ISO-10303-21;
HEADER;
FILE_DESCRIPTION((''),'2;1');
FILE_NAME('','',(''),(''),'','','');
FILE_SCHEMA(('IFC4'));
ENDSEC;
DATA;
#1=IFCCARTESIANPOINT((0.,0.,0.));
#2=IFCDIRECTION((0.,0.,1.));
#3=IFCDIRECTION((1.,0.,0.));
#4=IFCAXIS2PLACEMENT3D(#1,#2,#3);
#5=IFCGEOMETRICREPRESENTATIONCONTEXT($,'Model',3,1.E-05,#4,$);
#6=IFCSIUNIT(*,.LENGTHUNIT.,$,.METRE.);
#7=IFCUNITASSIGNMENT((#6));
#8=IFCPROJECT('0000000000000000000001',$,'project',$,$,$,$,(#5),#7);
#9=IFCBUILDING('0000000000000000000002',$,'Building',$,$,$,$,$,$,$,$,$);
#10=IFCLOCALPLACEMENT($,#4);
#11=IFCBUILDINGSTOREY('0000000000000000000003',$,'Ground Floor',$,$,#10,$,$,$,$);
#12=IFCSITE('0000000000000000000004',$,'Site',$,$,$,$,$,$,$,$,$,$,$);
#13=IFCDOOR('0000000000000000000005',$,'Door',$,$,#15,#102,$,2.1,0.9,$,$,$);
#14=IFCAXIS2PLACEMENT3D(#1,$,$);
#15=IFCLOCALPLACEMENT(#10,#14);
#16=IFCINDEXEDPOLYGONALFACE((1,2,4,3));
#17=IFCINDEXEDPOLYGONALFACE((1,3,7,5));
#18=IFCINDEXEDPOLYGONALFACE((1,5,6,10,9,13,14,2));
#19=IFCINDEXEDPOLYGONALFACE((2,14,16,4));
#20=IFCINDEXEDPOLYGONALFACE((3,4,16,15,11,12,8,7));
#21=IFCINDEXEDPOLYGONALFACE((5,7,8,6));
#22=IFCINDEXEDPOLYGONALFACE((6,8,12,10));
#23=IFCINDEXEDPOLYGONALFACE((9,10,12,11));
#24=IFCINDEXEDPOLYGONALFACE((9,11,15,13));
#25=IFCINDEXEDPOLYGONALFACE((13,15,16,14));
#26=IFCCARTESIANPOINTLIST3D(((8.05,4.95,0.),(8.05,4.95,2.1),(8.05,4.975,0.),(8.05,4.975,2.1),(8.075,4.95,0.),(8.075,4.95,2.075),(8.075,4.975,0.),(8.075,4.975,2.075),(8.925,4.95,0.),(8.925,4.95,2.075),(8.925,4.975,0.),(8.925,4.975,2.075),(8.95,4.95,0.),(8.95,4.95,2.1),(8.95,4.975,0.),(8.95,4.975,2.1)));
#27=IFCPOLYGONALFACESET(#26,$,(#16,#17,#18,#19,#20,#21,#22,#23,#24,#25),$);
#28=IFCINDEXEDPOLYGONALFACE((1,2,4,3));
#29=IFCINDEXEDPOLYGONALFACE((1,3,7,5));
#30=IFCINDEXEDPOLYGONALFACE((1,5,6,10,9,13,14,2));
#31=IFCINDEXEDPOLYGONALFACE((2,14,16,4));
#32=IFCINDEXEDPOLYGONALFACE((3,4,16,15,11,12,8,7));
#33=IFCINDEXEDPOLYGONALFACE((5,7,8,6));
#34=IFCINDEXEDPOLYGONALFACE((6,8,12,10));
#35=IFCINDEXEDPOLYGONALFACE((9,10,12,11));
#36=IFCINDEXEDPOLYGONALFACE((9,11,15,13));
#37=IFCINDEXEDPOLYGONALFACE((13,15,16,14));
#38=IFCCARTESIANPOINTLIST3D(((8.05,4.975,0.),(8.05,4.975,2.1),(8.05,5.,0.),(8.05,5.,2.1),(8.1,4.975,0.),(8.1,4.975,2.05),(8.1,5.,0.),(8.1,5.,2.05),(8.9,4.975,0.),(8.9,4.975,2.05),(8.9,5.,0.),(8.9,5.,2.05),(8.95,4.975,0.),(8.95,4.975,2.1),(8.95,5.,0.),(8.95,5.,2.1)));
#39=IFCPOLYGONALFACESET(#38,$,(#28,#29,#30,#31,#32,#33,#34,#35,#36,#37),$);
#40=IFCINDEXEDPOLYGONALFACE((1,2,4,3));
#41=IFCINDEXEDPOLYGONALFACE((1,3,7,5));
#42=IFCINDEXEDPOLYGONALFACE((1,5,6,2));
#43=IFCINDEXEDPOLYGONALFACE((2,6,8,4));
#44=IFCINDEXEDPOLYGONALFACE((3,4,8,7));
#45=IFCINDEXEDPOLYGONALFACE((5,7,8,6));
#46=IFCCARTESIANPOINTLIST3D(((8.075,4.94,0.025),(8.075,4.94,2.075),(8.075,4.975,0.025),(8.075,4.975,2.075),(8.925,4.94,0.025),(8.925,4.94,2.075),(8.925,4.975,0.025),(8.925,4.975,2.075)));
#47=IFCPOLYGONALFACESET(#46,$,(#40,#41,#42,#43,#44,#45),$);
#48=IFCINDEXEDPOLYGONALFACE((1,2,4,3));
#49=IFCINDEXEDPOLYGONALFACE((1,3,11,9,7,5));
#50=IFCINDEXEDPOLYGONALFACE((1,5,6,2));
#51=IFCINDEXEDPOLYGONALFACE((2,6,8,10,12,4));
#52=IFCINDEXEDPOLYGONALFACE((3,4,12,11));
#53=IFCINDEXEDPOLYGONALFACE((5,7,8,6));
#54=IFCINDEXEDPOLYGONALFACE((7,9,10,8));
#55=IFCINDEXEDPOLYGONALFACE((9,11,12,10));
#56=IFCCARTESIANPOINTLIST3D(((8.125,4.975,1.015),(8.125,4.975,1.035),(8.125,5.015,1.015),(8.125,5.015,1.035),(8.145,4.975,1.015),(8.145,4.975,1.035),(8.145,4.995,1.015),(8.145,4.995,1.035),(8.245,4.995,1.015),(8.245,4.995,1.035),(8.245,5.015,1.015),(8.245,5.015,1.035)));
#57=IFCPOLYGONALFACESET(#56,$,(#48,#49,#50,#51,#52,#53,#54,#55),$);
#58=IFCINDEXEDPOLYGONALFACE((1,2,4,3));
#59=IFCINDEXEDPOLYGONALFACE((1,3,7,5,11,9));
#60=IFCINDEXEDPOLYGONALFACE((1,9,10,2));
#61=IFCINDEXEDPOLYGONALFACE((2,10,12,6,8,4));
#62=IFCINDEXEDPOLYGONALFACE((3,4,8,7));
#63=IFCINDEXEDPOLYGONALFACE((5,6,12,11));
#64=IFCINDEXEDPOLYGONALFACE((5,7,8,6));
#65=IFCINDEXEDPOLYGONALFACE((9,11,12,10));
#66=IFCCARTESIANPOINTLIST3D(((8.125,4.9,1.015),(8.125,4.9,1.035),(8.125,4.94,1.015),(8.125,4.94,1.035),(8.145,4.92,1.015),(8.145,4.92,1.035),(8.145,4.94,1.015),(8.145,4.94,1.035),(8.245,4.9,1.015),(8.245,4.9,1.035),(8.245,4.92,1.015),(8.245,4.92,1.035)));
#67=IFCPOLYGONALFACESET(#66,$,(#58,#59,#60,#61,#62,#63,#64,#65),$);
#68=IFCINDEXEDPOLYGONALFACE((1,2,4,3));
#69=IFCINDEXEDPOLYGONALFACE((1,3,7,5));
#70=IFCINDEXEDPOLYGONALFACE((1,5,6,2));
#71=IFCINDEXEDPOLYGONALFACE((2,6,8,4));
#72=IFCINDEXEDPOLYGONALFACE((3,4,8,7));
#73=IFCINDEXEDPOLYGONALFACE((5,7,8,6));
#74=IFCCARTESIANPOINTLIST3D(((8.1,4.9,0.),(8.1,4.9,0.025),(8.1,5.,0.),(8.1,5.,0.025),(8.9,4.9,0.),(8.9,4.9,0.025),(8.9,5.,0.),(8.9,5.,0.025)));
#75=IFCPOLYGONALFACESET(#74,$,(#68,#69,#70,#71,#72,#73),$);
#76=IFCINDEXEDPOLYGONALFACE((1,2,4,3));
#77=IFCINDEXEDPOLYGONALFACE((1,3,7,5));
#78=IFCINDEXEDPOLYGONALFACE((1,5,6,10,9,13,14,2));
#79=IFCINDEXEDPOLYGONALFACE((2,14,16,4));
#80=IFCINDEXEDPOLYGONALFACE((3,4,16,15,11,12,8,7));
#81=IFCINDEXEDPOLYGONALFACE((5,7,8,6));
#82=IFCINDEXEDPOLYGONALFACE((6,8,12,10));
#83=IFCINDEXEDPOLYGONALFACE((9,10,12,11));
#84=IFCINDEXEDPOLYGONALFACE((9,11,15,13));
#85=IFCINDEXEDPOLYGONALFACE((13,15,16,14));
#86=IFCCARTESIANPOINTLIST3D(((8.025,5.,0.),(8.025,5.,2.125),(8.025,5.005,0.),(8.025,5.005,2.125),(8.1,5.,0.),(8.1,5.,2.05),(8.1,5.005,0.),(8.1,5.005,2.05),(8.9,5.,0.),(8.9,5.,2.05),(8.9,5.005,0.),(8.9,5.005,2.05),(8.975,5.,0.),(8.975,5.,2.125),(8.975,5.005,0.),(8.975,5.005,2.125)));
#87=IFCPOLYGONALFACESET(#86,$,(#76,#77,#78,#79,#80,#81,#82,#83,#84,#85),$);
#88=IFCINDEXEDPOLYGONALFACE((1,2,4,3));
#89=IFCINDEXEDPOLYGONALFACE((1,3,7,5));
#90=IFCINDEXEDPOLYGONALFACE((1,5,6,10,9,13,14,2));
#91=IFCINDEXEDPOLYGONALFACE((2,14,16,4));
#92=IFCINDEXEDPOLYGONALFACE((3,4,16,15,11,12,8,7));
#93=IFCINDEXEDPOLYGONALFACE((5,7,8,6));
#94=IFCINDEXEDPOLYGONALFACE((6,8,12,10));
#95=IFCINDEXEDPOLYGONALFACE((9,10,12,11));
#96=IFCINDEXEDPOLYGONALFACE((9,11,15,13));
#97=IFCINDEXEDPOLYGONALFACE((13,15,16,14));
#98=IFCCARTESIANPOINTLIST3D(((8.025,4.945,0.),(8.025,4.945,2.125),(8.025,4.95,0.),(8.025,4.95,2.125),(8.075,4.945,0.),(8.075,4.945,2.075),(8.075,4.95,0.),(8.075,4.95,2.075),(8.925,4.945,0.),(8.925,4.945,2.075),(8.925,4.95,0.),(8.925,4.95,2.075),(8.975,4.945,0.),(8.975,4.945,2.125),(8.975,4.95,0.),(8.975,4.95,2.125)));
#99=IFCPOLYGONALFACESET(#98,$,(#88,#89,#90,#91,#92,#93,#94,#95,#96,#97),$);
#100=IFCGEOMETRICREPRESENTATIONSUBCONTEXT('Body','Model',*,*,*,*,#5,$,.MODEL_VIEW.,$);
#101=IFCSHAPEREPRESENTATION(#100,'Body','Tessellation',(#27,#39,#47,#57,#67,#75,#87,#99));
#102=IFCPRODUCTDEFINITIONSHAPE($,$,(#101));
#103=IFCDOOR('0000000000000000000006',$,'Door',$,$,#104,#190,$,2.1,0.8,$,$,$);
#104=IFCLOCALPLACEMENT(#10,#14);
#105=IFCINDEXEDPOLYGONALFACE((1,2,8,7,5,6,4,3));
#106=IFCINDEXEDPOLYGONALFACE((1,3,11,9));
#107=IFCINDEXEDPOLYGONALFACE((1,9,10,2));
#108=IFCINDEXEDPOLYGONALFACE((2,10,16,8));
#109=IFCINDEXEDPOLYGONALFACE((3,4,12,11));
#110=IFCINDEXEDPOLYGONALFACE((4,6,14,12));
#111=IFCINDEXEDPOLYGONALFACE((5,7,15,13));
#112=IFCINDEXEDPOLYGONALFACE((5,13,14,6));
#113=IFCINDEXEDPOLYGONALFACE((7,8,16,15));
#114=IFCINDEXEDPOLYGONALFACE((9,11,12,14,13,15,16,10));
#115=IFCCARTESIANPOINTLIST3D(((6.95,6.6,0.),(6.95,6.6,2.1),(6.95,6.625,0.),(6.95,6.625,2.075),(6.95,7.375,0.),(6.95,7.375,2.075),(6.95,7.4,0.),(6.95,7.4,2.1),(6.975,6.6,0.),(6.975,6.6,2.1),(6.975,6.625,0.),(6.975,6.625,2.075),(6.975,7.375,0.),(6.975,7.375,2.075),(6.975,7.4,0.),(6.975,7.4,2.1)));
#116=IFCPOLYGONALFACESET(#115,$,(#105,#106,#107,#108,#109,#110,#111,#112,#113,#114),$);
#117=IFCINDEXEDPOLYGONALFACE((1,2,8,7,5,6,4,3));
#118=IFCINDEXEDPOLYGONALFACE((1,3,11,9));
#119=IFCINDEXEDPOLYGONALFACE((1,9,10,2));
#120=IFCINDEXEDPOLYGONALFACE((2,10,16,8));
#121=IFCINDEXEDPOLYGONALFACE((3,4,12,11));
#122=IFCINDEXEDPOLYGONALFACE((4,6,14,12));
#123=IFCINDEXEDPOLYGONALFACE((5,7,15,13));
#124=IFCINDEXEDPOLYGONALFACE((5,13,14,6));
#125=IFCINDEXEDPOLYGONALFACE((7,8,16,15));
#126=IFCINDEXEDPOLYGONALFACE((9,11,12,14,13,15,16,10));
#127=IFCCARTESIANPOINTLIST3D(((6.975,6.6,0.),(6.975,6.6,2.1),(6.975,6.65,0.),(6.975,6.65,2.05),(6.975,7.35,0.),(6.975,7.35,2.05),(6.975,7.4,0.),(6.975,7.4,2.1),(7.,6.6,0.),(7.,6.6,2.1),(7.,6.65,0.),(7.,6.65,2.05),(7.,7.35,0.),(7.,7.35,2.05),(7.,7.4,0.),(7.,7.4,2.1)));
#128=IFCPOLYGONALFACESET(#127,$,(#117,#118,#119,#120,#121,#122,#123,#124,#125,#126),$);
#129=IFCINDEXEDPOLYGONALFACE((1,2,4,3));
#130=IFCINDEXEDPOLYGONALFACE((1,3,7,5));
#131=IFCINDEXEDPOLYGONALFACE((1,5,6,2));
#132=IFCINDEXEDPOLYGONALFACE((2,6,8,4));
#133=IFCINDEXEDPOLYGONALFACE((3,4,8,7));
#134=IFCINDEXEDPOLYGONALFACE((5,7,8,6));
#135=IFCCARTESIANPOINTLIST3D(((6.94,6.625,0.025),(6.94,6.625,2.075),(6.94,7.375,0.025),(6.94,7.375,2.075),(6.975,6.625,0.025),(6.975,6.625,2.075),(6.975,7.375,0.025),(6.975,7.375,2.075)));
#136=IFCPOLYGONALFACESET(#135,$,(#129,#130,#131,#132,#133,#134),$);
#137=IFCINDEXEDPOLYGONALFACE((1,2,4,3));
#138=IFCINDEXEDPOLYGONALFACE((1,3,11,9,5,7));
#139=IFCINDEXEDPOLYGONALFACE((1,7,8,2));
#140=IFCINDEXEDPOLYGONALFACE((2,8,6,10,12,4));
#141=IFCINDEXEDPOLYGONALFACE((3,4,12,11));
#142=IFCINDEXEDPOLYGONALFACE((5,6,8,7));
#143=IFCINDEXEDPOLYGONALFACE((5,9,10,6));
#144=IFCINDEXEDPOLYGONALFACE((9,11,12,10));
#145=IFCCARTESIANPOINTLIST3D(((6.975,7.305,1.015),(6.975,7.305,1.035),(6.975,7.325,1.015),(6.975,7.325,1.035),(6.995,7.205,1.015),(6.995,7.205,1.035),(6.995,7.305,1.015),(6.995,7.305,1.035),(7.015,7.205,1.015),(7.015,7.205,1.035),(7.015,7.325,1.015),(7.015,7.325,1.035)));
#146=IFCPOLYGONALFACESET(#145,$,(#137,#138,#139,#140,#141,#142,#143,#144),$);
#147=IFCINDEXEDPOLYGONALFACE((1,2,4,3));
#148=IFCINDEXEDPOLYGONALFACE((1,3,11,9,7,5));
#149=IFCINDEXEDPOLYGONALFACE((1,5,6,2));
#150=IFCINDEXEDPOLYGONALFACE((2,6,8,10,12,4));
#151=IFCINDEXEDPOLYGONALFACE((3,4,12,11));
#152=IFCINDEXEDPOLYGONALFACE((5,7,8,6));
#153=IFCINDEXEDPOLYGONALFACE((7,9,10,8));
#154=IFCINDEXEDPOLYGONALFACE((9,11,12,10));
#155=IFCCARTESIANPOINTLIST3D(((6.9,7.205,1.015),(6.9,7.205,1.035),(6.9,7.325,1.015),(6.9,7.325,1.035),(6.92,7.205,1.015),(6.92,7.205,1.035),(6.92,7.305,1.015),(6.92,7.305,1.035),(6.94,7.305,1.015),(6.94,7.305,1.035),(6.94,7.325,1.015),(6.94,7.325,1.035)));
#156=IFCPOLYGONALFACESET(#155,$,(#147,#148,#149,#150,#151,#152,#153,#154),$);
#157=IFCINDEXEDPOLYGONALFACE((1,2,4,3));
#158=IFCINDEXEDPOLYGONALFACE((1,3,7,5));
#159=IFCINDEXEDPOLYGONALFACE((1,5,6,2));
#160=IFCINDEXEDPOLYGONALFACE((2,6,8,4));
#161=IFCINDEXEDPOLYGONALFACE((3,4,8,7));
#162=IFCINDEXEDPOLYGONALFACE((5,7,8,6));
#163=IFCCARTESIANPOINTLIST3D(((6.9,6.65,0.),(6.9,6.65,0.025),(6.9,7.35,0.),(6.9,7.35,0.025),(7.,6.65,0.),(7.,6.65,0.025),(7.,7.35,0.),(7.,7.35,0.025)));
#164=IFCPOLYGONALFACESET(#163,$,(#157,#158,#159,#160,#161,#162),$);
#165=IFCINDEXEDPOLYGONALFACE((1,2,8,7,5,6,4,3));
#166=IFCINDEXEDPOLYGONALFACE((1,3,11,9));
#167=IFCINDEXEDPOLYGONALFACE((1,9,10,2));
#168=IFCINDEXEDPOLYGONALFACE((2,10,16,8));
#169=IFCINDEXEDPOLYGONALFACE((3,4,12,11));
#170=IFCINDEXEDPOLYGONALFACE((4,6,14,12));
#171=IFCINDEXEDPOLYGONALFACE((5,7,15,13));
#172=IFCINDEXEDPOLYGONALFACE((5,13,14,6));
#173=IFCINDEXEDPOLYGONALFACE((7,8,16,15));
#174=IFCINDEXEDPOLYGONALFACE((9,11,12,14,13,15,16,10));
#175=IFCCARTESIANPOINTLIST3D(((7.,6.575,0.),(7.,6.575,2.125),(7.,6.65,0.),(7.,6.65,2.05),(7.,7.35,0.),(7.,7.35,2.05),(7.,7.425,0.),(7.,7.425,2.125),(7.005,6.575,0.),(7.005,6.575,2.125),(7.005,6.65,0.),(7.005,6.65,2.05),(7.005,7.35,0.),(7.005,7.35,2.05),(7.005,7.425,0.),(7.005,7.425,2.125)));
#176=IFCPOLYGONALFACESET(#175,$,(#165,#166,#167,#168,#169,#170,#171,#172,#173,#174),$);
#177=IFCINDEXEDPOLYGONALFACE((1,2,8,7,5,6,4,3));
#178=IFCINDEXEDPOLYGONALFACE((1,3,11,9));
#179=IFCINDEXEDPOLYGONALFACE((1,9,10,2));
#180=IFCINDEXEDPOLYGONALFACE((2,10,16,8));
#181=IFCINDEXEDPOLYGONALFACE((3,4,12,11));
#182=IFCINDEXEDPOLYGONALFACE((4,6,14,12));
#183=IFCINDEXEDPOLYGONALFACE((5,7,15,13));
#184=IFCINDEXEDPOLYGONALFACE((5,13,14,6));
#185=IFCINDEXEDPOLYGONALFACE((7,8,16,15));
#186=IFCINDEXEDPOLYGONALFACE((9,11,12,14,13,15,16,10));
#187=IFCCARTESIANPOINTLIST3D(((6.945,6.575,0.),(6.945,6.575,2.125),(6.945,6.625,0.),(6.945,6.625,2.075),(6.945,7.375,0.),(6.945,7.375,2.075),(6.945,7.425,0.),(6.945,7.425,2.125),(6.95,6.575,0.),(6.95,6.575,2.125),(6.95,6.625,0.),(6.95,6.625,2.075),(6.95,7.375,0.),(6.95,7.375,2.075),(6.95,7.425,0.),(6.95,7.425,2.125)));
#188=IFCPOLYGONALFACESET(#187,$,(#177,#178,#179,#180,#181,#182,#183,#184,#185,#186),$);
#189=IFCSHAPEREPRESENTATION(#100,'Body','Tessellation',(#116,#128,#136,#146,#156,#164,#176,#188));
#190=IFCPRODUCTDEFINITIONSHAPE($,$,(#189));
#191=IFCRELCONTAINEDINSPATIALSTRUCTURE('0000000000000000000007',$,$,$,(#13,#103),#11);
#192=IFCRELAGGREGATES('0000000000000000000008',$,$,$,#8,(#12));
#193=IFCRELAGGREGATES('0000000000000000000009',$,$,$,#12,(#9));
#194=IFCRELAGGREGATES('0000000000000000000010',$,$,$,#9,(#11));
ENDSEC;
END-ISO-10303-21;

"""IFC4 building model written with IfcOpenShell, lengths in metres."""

from ifc_helpers import new_model, si_unit, frame, origin_with_axes, place, context, subcontext, project, spatial, line, indexed_curve, outline, extrude, element, save


model = new_model("IFC4")

# Units and contexts
model_context = context("Model", 3, precision=1e-05, world=origin_with_axes())
body_context = subcontext(model_context, "Body", "Model", "MODEL_VIEW")
ifc_project = project(units=[si_unit("LENGTHUNIT", "METRE")], contexts=[model_context])

# Site, building, storey
site = spatial("IfcSite", under=ifc_project, Name="Site")
building = spatial("IfcBuilding", under=site, Name="Building")
storey_placement = place(None, origin_with_axes())
storey = spatial("IfcBuildingStorey", under=building, at=storey_placement, Name="Ground Floor")

# Doors
door_1_placement = place(storey_placement, frame((8.95, 5.0, 0.0), z_axis=(0.0, 0.0, 1.0), x_axis=(-1.0, 0.0, 0.0)))
element("IfcDoor", 1, at=door_1_placement, inside=storey, Name="Door", OverallHeight=2.1, OverallWidth=0.9, context=body_context, shape_type="SweptSolid", body=[
    extrude(outline(indexed_curve([(0.0, 0.0), (0.0, 2.1), (0.9, 2.1), (0.9, 0.0), (0.875, 0.0), (0.875, 2.075), (0.025, 2.075), (0.025, 0.0)], segments=[line(1, 2, 3, 4, 5, 6, 7, 8, 1)])), frame((0.0, 0.025, 0.0), z_axis=(0.0, -1.0, 0.0), x_axis=(1.0, 0.0, 0.0)), (0.0, 0.0, -1.0), 0.025),
    extrude(outline(indexed_curve([(0.0, 0.0), (0.0, 2.1), (0.9, 2.1), (0.9, 0.0), (0.85, 0.0), (0.85, 2.05), (0.05, 2.05), (0.05, 0.0)], segments=[line(1, 2, 3, 4, 5, 6, 7, 8, 1)])), frame((0.0, 0.0, 0.0), z_axis=(0.0, -1.0, 0.0), x_axis=(1.0, 0.0, 0.0)), (0.0, 0.0, -1.0), 0.025),
    extrude(outline(indexed_curve([(0.0, 0.0), (0.85, 0.0), (0.85, 0.035), (0.0, 0.035)], segments=[line(1, 2, 3, 4, 1)])), frame((0.025, 0.025, 0.025), z_axis=(0.0, 0.0, 1.0), x_axis=(1.0, 0.0, 0.0)), (0.0, 0.0, 1.0), 2.05),
    extrude(outline(indexed_curve([(0.0, 0.0), (0.0, -0.04), (-0.12, -0.04), (-0.12, -0.02), (-0.02, -0.02), (-0.02, 0.0)], segments=[line(1, 2, 3, 4, 5, 6, 1)])), frame((0.825, 0.025, 1.015), z_axis=(0.0, 0.0, 1.0), x_axis=(1.0, 0.0, 0.0)), (0.0, 0.0, 1.0), 0.02),
    extrude(outline(indexed_curve([(0.0, 0.0), (0.0, 0.04), (-0.12, 0.04), (-0.12, 0.02), (-0.02, 0.02), (-0.02, 0.0)], segments=[line(1, 2, 3, 4, 5, 6, 1)])), frame((0.825, 0.06, 1.015), z_axis=(0.0, 0.0, 1.0), x_axis=(1.0, 0.0, 0.0)), (0.0, 0.0, 1.0), 0.02),
    extrude(outline(indexed_curve([(0.0, 0.0), (0.8, 0.0), (0.8, 0.1), (0.0, 0.1)], segments=[line(1, 2, 3, 4, 1)])), frame((0.05, 0.0, 0.0), z_axis=(0.0, 0.0, 1.0), x_axis=(1.0, 0.0, 0.0)), (0.0, 0.0, 1.0), 0.025),
    extrude(outline(indexed_curve([(0.0, 0.0), (0.0, 2.125), (0.95, 2.125), (0.95, 0.0), (0.875, 0.0), (0.875, 2.05), (0.075, 2.05), (0.075, 0.0)], segments=[line(1, 2, 3, 4, 5, 6, 7, 8, 1)])), frame((-0.025, -0.005, 0.0), z_axis=(0.0, -1.0, 0.0), x_axis=(1.0, 0.0, 0.0)), (0.0, 0.0, -1.0), 0.005),
    extrude(outline(indexed_curve([(0.0, 0.0), (0.0, 2.125), (0.95, 2.125), (0.95, 0.0), (0.9, 0.0), (0.9, 2.075), (0.05, 2.075), (0.05, 0.0)], segments=[line(1, 2, 3, 4, 5, 6, 7, 8, 1)])), frame((-0.025, 0.05, 0.0), z_axis=(0.0, -1.0, 0.0), x_axis=(1.0, 0.0, 0.0)), (0.0, 0.0, -1.0), 0.005),
])
door_2_placement = place(storey_placement, frame((7.0, 6.6, 0.0), z_axis=(0.0, 0.0, 1.0), x_axis=(0.0, 1.0, 0.0)))
element("IfcDoor", 2, at=door_2_placement, inside=storey, Name="Door", OverallHeight=2.1, OverallWidth=0.8, context=body_context, shape_type="SweptSolid", body=[
    extrude(outline(indexed_curve([(0.0, 0.0), (0.0, 2.1), (0.8, 2.1), (0.8, 0.0), (0.775, 0.0), (0.775, 2.075), (0.025, 2.075), (0.025, 0.0)], segments=[line(1, 2, 3, 4, 5, 6, 7, 8, 1)])), frame((0.0, 0.025, 0.0), z_axis=(0.0, -1.0, 0.0), x_axis=(1.0, 0.0, 0.0)), (0.0, 0.0, -1.0), 0.025),
    extrude(outline(indexed_curve([(0.0, 0.0), (0.0, 2.1), (0.8, 2.1), (0.8, 0.0), (0.75, 0.0), (0.75, 2.05), (0.05, 2.05), (0.05, 0.0)], segments=[line(1, 2, 3, 4, 5, 6, 7, 8, 1)])), frame((0.0, 0.0, 0.0), z_axis=(0.0, -1.0, 0.0), x_axis=(1.0, 0.0, 0.0)), (0.0, 0.0, -1.0), 0.025),
    extrude(outline(indexed_curve([(0.0, 0.0), (0.75, 0.0), (0.75, 0.035), (0.0, 0.035)], segments=[line(1, 2, 3, 4, 1)])), frame((0.025, 0.025, 0.025), z_axis=(0.0, 0.0, 1.0), x_axis=(1.0, 0.0, 0.0)), (0.0, 0.0, 1.0), 2.05),
    extrude(outline(indexed_curve([(0.0, 0.0), (0.0, -0.04), (-0.12, -0.04), (-0.12, -0.02), (-0.02, -0.02), (-0.02, 0.0)], segments=[line(1, 2, 3, 4, 5, 6, 1)])), frame((0.725, 0.025, 1.015), z_axis=(0.0, 0.0, 1.0), x_axis=(1.0, 0.0, 0.0)), (0.0, 0.0, 1.0), 0.02),
    extrude(outline(indexed_curve([(0.0, 0.0), (0.0, 0.04), (-0.12, 0.04), (-0.12, 0.02), (-0.02, 0.02), (-0.02, 0.0)], segments=[line(1, 2, 3, 4, 5, 6, 1)])), frame((0.725, 0.06, 1.015), z_axis=(0.0, 0.0, 1.0), x_axis=(1.0, 0.0, 0.0)), (0.0, 0.0, 1.0), 0.02),
    extrude(outline(indexed_curve([(0.0, 0.0), (0.7, 0.0), (0.7, 0.1), (0.0, 0.1)], segments=[line(1, 2, 3, 4, 1)])), frame((0.05, 0.0, 0.0), z_axis=(0.0, 0.0, 1.0), x_axis=(1.0, 0.0, 0.0)), (0.0, 0.0, 1.0), 0.025),
    extrude(outline(indexed_curve([(0.0, 0.0), (0.0, 2.125), (0.85, 2.125), (0.85, 0.0), (0.775, 0.0), (0.775, 2.05), (0.075, 2.05), (0.075, 0.0)], segments=[line(1, 2, 3, 4, 5, 6, 7, 8, 1)])), frame((-0.025, -0.005, 0.0), z_axis=(0.0, -1.0, 0.0), x_axis=(1.0, 0.0, 0.0)), (0.0, 0.0, -1.0), 0.005),
    extrude(outline(indexed_curve([(0.0, 0.0), (0.0, 2.125), (0.85, 2.125), (0.85, 0.0), (0.8, 0.0), (0.8, 2.075), (0.05, 2.075), (0.05, 0.0)], segments=[line(1, 2, 3, 4, 5, 6, 7, 8, 1)])), frame((-0.025, 0.05, 0.0), z_axis=(0.0, -1.0, 0.0), x_axis=(1.0, 0.0, 0.0)), (0.0, 0.0, -1.0), 0.005),
])

save(model, "model.ifc")
